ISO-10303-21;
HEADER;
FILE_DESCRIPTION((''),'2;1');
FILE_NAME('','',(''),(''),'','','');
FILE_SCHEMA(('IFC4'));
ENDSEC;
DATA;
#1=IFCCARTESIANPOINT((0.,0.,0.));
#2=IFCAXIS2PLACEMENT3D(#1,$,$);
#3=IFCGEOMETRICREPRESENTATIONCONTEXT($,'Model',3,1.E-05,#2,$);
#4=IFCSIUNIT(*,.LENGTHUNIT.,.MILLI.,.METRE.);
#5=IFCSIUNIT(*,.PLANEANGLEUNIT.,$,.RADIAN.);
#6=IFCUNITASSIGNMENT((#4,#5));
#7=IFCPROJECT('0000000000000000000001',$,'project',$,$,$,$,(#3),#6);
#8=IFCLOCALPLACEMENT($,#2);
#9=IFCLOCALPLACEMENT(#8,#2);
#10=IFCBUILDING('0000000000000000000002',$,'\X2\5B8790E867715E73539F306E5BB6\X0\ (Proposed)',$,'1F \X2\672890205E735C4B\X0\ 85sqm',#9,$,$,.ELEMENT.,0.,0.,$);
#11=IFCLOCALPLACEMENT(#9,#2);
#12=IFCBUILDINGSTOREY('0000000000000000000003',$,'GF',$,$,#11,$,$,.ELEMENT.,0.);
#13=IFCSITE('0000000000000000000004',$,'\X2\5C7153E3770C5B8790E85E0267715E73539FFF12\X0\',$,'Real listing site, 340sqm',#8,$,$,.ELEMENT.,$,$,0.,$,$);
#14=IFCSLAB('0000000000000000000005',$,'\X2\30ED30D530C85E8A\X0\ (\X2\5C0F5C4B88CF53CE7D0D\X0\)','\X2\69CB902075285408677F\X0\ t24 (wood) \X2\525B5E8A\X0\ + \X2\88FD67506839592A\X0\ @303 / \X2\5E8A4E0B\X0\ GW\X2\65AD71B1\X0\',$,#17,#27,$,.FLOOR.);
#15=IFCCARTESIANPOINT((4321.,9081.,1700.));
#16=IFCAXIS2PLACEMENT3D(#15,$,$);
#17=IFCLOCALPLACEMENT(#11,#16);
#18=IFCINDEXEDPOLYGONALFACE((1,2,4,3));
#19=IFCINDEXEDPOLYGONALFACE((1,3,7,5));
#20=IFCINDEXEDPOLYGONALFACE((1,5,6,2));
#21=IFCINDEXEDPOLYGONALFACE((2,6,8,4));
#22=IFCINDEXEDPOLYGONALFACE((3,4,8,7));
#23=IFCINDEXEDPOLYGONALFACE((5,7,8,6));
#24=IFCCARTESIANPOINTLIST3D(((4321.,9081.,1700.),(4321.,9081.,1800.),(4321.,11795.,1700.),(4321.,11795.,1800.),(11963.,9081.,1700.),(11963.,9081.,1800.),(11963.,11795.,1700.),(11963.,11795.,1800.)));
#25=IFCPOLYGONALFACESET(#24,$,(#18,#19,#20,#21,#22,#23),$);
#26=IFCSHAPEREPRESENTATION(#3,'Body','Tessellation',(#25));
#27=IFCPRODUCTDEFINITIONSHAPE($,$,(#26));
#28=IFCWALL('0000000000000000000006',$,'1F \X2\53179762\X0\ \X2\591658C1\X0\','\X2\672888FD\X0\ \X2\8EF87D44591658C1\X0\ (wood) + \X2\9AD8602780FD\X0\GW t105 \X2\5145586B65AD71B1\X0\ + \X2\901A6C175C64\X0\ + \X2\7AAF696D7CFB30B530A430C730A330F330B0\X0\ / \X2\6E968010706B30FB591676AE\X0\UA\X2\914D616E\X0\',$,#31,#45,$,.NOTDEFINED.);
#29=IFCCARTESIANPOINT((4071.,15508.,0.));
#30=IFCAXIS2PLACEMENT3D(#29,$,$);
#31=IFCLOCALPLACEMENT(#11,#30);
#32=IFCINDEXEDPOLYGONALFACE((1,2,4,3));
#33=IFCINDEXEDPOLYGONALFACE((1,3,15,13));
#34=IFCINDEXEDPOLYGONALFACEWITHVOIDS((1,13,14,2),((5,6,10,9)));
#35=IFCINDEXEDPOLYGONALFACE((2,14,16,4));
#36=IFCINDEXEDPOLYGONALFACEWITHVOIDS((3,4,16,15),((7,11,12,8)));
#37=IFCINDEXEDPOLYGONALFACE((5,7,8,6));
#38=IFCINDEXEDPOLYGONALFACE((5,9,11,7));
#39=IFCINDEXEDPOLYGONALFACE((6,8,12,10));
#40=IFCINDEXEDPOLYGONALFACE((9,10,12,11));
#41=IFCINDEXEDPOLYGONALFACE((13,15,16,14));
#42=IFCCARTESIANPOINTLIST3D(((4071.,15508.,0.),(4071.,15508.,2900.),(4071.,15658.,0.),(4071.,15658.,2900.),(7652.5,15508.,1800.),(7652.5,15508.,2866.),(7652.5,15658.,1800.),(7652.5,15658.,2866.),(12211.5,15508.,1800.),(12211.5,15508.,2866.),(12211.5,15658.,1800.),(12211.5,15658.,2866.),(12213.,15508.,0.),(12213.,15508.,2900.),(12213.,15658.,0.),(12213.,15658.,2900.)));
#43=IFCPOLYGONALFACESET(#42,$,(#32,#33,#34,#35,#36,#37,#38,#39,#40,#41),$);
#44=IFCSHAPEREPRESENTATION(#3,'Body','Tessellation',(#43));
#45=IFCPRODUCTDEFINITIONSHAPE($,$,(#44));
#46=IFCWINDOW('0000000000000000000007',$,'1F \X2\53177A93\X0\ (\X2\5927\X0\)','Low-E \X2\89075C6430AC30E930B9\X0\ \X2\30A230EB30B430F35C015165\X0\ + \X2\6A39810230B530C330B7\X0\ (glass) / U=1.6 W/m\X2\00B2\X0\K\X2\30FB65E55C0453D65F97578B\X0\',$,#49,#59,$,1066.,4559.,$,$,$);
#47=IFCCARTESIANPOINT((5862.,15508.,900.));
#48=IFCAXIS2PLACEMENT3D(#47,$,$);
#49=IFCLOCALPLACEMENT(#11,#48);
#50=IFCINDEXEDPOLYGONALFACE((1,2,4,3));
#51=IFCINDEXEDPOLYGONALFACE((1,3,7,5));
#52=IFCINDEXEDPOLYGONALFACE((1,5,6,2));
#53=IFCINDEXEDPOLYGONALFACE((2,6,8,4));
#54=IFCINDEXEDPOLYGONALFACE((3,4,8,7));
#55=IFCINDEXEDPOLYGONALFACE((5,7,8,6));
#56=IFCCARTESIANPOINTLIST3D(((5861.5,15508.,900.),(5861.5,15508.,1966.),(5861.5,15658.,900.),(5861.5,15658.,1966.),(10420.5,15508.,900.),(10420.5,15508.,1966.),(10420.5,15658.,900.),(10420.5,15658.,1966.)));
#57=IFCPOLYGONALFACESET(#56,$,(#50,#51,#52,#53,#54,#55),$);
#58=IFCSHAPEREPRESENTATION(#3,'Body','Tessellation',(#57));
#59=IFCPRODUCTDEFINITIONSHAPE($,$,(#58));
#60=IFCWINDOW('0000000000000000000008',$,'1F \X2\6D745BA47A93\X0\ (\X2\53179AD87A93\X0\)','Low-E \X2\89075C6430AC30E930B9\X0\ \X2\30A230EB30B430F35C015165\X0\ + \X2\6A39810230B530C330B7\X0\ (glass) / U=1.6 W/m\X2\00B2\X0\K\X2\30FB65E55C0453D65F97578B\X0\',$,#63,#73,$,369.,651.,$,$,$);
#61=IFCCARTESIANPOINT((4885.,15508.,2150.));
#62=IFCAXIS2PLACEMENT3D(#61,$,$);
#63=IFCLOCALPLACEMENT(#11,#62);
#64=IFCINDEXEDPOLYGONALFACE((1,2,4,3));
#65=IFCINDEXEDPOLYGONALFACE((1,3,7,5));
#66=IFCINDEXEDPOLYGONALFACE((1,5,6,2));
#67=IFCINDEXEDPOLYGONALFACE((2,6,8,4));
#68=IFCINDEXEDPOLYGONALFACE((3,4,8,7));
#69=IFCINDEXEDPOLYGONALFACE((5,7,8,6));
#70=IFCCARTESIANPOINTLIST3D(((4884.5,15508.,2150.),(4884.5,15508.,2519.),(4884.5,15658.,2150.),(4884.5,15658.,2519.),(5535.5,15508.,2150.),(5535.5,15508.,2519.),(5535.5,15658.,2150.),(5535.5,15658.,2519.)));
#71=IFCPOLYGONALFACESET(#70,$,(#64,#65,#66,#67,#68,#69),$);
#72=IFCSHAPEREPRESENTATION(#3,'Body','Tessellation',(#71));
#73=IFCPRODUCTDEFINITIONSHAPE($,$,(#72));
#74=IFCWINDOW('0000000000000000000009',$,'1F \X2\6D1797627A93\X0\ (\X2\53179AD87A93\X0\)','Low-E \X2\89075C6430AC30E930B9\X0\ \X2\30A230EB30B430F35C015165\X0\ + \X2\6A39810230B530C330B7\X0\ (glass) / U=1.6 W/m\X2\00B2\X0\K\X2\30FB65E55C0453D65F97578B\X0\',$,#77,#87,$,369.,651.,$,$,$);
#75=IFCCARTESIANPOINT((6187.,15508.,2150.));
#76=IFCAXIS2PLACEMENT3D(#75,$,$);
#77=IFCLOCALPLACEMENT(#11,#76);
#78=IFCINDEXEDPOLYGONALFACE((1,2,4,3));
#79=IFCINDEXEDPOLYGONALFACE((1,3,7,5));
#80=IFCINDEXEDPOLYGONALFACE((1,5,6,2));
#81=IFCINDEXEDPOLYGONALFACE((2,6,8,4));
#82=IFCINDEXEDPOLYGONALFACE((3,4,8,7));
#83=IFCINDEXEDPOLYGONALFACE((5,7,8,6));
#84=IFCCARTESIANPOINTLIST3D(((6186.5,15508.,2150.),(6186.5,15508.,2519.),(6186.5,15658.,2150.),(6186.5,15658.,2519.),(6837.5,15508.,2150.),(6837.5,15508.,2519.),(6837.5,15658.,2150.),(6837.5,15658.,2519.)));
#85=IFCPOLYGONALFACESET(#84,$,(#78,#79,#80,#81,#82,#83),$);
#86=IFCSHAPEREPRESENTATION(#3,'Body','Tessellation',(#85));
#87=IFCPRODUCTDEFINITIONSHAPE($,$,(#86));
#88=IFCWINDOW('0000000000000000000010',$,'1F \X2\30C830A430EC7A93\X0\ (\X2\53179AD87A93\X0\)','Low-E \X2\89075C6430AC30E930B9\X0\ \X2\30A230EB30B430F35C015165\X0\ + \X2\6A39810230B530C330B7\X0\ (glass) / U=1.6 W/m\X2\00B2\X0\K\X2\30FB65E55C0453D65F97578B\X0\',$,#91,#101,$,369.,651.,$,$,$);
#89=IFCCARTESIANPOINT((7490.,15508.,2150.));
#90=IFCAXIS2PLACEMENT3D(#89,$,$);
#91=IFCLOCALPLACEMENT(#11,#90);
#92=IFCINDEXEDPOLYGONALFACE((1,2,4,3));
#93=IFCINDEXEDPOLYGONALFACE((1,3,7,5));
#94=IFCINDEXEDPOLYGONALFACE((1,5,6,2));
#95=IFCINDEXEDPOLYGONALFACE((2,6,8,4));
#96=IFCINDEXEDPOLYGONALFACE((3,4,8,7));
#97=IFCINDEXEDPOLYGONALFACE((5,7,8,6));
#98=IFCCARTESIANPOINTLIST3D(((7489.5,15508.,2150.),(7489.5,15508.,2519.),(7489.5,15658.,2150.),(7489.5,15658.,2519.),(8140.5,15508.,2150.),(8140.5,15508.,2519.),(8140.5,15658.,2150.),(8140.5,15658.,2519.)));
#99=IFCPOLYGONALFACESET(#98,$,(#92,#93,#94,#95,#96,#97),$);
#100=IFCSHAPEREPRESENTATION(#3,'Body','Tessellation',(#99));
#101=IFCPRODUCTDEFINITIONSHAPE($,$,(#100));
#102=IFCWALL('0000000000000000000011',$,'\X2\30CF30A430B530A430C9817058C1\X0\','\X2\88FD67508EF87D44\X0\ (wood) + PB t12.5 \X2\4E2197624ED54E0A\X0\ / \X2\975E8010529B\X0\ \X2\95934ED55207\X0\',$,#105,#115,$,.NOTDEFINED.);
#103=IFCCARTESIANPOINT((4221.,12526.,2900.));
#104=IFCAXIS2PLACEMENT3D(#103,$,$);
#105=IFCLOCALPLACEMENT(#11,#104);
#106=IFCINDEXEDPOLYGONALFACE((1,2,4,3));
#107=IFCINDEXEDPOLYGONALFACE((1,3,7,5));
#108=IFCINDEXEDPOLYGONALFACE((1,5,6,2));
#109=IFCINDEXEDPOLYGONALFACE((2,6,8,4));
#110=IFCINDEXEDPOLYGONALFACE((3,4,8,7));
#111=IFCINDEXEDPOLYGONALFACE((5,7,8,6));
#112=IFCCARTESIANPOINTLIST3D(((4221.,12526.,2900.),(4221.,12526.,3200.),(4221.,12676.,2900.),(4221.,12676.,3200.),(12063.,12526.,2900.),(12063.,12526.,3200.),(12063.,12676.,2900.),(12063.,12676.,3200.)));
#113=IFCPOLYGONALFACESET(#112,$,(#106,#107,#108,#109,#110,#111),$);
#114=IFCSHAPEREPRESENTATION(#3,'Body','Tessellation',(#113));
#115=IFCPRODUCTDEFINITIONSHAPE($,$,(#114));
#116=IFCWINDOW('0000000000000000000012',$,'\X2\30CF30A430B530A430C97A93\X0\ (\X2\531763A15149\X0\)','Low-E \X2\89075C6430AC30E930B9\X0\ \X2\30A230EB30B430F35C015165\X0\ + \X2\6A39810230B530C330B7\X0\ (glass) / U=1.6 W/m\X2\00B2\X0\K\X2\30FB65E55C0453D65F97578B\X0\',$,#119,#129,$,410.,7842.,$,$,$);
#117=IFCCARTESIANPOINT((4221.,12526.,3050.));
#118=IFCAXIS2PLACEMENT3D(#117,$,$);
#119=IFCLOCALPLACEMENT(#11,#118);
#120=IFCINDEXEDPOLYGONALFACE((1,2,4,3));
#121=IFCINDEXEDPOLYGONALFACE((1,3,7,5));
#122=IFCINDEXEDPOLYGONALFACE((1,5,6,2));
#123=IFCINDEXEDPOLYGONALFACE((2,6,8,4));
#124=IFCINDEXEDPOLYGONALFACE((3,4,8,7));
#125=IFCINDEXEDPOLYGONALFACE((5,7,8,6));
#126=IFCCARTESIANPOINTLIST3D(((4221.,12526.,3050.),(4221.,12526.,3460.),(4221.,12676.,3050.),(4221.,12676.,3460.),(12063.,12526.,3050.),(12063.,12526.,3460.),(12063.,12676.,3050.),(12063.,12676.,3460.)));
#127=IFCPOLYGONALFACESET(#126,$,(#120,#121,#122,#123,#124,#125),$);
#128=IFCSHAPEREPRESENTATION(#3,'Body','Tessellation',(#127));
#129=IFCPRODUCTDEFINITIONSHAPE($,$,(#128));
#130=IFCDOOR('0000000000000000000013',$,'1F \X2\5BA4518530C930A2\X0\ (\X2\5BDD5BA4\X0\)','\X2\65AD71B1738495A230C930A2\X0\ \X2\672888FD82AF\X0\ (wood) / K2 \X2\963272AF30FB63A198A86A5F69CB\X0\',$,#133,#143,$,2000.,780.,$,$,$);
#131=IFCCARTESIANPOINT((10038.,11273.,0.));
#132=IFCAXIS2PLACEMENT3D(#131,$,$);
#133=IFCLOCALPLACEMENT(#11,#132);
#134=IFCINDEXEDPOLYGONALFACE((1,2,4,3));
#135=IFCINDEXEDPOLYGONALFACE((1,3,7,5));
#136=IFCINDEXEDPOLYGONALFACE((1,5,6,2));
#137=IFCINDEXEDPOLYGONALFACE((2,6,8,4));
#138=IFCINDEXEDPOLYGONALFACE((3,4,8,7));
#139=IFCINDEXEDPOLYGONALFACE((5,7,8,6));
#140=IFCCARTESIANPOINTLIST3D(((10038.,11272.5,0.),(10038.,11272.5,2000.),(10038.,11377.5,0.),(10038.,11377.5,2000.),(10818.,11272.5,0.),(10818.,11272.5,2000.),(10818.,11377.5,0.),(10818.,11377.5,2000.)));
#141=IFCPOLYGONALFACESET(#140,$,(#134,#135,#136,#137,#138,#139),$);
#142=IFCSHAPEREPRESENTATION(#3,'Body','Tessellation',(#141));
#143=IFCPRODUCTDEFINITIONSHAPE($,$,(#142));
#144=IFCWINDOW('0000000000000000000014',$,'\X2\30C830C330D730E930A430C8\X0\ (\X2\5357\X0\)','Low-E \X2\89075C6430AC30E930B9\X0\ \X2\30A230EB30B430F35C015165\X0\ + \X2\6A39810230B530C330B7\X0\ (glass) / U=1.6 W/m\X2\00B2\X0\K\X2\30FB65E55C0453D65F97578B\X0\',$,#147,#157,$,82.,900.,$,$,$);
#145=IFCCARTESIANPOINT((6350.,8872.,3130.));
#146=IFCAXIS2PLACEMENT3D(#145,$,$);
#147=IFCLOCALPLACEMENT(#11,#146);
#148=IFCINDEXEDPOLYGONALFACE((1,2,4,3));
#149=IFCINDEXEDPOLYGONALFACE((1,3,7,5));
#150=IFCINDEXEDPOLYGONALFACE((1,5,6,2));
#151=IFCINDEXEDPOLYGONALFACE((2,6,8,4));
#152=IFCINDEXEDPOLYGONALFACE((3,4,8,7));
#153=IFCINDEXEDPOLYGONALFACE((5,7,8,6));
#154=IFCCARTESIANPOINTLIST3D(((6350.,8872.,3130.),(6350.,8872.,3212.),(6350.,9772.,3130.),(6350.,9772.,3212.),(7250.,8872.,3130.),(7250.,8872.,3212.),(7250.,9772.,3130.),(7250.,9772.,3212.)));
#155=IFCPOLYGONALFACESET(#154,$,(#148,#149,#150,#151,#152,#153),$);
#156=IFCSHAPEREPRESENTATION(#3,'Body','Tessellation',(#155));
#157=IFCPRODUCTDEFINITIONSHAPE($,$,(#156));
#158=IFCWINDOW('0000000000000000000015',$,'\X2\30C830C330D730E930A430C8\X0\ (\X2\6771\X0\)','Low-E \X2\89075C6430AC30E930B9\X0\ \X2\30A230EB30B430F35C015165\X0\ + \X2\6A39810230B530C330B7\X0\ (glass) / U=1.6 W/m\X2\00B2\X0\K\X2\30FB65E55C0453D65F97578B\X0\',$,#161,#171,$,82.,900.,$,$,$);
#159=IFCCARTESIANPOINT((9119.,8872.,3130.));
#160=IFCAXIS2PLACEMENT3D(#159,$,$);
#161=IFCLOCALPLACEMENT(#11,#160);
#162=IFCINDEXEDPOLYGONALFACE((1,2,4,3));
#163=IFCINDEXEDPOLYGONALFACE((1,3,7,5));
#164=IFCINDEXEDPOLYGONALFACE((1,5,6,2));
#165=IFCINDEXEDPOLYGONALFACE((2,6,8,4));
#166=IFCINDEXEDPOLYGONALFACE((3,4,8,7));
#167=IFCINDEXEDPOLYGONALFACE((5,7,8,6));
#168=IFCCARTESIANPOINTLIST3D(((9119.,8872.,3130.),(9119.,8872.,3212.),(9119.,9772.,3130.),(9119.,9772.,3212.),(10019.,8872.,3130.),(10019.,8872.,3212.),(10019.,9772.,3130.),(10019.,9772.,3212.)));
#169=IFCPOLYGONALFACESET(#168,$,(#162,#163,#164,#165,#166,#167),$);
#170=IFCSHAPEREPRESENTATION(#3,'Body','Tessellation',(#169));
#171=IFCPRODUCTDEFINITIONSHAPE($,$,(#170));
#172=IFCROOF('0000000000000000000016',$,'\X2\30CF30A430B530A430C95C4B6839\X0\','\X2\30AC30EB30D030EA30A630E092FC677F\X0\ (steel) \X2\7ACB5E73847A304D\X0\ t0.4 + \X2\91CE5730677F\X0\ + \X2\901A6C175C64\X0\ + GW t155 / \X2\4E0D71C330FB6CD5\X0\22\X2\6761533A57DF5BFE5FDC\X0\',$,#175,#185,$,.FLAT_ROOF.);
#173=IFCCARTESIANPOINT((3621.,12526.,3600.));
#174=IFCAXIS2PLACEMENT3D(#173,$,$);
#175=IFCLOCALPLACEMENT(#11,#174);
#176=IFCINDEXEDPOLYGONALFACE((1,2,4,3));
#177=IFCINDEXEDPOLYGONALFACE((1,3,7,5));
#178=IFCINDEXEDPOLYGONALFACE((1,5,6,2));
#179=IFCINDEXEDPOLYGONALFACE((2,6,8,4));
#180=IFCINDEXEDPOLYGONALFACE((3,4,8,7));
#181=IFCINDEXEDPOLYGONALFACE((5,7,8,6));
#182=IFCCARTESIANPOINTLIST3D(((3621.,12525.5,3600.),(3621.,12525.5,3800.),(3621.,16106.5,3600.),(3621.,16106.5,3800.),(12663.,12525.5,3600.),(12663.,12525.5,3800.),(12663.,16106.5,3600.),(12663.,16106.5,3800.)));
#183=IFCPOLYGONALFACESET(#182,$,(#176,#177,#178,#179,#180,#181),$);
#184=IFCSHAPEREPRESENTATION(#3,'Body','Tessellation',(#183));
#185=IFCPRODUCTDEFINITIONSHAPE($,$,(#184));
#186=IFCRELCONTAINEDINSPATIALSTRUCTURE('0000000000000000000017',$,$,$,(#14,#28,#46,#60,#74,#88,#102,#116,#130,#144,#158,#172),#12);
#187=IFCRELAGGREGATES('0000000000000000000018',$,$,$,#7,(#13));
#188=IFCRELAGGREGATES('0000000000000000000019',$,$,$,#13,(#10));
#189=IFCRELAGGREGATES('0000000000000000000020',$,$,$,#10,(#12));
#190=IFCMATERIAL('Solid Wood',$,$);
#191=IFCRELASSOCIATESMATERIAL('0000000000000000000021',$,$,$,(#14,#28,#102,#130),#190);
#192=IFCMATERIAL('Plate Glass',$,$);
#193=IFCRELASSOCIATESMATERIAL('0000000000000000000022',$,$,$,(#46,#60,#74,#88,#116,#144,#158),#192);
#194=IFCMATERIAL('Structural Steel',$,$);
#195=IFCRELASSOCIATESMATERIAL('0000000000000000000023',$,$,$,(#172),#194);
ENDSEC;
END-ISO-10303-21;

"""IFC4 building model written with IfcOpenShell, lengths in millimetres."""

from ifc_helpers import new_model, si_unit, frame, frame_2d, origin, place, context, project, spatial, rectangle, extrude, material, element, fill, save


model = new_model("IFC4")

# Units and contexts
model_context = context("Model", 3, precision=1e-05, world=origin())
ifc_project = project(units=[si_unit("LENGTHUNIT", "METRE", prefix="MILLI"), si_unit("PLANEANGLEUNIT", "RADIAN")], contexts=[model_context])

# Site, building, storey
site_placement = place(None, origin())
site = spatial("IfcSite", under=ifc_project, at=site_placement, Name="山口県宇部市東平原２", ObjectType="Real listing site, 340sqm", CompositionType="ELEMENT", RefElevation=0.0)
building_placement = place(site_placement, origin())
building = spatial("IfcBuilding", under=site, at=building_placement, Name="宇部東平原の家 (Proposed)", ObjectType="1F 木造平屋 85sqm", CompositionType="ELEMENT", ElevationOfRefHeight=0.0, ElevationOfTerrain=0.0)
storey_placement = place(building_placement, origin())
storey = spatial("IfcBuildingStorey", under=building, at=storey_placement, Name="GF", CompositionType="ELEMENT", Elevation=0.0)

# Slab
ifc_material_1 = material(Name="Solid Wood")
slab_placement = place(storey_placement, frame((4321.0, 9081.0, 1700.0)))
element("IfcSlab", 1, at=slab_placement, inside=storey, material=ifc_material_1, Name="ロフト床 (小屋裏収納)", Description="構造用合板 t24 (wood) 剛床 + 製材根太 @303 / 床下 GW断熱", PredefinedType="FLOOR", context=model_context, shape_type="SweptSolid", body=[
    extrude(rectangle(XDim=7642.0, YDim=2714.0, at=frame_2d((3821.0, 1357.0))), frame((4321.0, 9081.0, 1700.0)), (0.0, 0.0, 1.0), 100.0),
])

# Wall, openings, windows
wall_1_placement = place(storey_placement, frame((4071.0, 15508.0, 0.0)))
wall_1 = element("IfcWall", 2, at=wall_1_placement, inside=storey, material=ifc_material_1, Name="1F 北面 外壁", Description="木製 軸組外壁 (wood) + 高性能GW t105 充填断熱 + 通気層 + 窯業系サイディング / 準耐火・外皮UA配慮", PredefinedType="NOTDEFINED", context=model_context, shape_type="SweptSolid", body=[
    extrude(rectangle(XDim=8142.0, YDim=150.0, at=frame_2d((4071.0, 75.0))), frame((4071.0, 15508.0, 0.0)), (0.0, 0.0, 1.0), 2900.0),
])
opening_1_placement = place(storey_placement, frame((5862.0, 15508.0, 900.0)))
opening_1 = element("IfcOpeningElement", 3, at=opening_1_placement, cuts=wall_1, PredefinedType="NOTDEFINED", context=model_context, shape_type="SweptSolid", body=[
    extrude(rectangle(XDim=4559.0, YDim=150.0, at=frame_2d((2279.0, 75.0))), frame((5862.0, 15508.0, 900.0)), (0.0, 0.0, 1.0), 1066.0),
])
opening_2_placement = place(storey_placement, frame((4885.0, 15508.0, 2150.0)))
opening_2 = element("IfcOpeningElement", 4, at=opening_2_placement, cuts=wall_1, PredefinedType="NOTDEFINED", context=model_context, shape_type="SweptSolid", body=[
    extrude(rectangle(XDim=651.0, YDim=150.0, at=frame_2d((325.0, 75.0))), frame((4885.0, 15508.0, 2150.0)), (0.0, 0.0, 1.0), 369.0),
])
opening_3_placement = place(storey_placement, frame((6187.0, 15508.0, 2150.0)))
opening_3 = element("IfcOpeningElement", 5, at=opening_3_placement, cuts=wall_1, PredefinedType="NOTDEFINED", context=model_context, shape_type="SweptSolid", body=[
    extrude(rectangle(XDim=651.0, YDim=150.0, at=frame_2d((325.0, 75.0))), frame((6187.0, 15508.0, 2150.0)), (0.0, 0.0, 1.0), 369.0),
])
opening_4_placement = place(storey_placement, frame((7490.0, 15508.0, 2150.0)))
opening_4 = element("IfcOpeningElement", 6, at=opening_4_placement, cuts=wall_1, PredefinedType="NOTDEFINED", context=model_context, shape_type="SweptSolid", body=[
    extrude(rectangle(XDim=651.0, YDim=150.0, at=frame_2d((325.0, 75.0))), frame((7490.0, 15508.0, 2150.0)), (0.0, 0.0, 1.0), 369.0),
])
ifc_material_2 = material(Name="Plate Glass")
window_1_placement = place(storey_placement, frame((5862.0, 15508.0, 900.0)))
window_1 = element("IfcWindow", 7, at=window_1_placement, inside=storey, material=ifc_material_2, Name="1F 北窓 (大)", Description="Low-E 複層ガラス アルゴン封入 + 樹脂サッシ (glass) / U=1.6 W/m²K・日射取得型", OverallHeight=1066.0, OverallWidth=4559.0, context=model_context, shape_type="SweptSolid", body=[
    extrude(rectangle(XDim=4559.0, YDim=150.0, at=frame_2d((2279.0, 75.0))), frame((5862.0, 15508.0, 900.0)), (0.0, 0.0, 1.0), 1066.0),
])
fill(opening_1, window_1)
window_2_placement = place(storey_placement, frame((4885.0, 15508.0, 2150.0)))
window_2 = element("IfcWindow", 8, at=window_2_placement, inside=storey, material=ifc_material_2, Name="1F 浴室窓 (北高窓)", Description="Low-E 複層ガラス アルゴン封入 + 樹脂サッシ (glass) / U=1.6 W/m²K・日射取得型", OverallHeight=369.0, OverallWidth=651.0, context=model_context, shape_type="SweptSolid", body=[
    extrude(rectangle(XDim=651.0, YDim=150.0, at=frame_2d((325.0, 75.0))), frame((4885.0, 15508.0, 2150.0)), (0.0, 0.0, 1.0), 369.0),
])
fill(opening_2, window_2)
window_3_placement = place(storey_placement, frame((6187.0, 15508.0, 2150.0)))
window_3 = element("IfcWindow", 9, at=window_3_placement, inside=storey, material=ifc_material_2, Name="1F 洗面窓 (北高窓)", Description="Low-E 複層ガラス アルゴン封入 + 樹脂サッシ (glass) / U=1.6 W/m²K・日射取得型", OverallHeight=369.0, OverallWidth=651.0, context=model_context, shape_type="SweptSolid", body=[
    extrude(rectangle(XDim=651.0, YDim=150.0, at=frame_2d((325.0, 75.0))), frame((6187.0, 15508.0, 2150.0)), (0.0, 0.0, 1.0), 369.0),
])
fill(opening_3, window_3)
window_4_placement = place(storey_placement, frame((7490.0, 15508.0, 2150.0)))
window_4 = element("IfcWindow", 10, at=window_4_placement, inside=storey, material=ifc_material_2, Name="1F トイレ窓 (北高窓)", Description="Low-E 複層ガラス アルゴン封入 + 樹脂サッシ (glass) / U=1.6 W/m²K・日射取得型", OverallHeight=369.0, OverallWidth=651.0, context=model_context, shape_type="SweptSolid", body=[
    extrude(rectangle(XDim=651.0, YDim=150.0, at=frame_2d((325.0, 75.0))), frame((7490.0, 15508.0, 2150.0)), (0.0, 0.0, 1.0), 369.0),
])
fill(opening_4, window_4)

# Wall, opening, window
wall_2_placement = place(storey_placement, frame((4221.0, 12526.0, 2900.0)))
wall_2 = element("IfcWall", 11, at=wall_2_placement, inside=storey, material=ifc_material_1, Name="ハイサイド腰壁", Description="製材軸組 (wood) + PB t12.5 両面仕上 / 非耐力 間仕切", PredefinedType="NOTDEFINED", context=model_context, shape_type="SweptSolid", body=[
    extrude(rectangle(XDim=7842.0, YDim=150.0, at=frame_2d((3921.0, 75.0))), frame((4221.0, 12526.0, 2900.0)), (0.0, 0.0, 1.0), 700.0),
])
opening_5_placement = place(storey_placement, frame((4221.0, 12526.0, 3050.0)))
opening_5 = element("IfcOpeningElement", 12, at=opening_5_placement, cuts=wall_2, PredefinedType="NOTDEFINED", context=model_context, shape_type="SweptSolid", body=[
    extrude(rectangle(XDim=7842.0, YDim=150.0, at=frame_2d((3921.0, 75.0))), frame((4221.0, 12526.0, 3050.0)), (0.0, 0.0, 1.0), 410.0),
])
window_5_placement = place(storey_placement, frame((4221.0, 12526.0, 3050.0)))
window_5 = element("IfcWindow", 13, at=window_5_placement, inside=storey, material=ifc_material_2, Name="ハイサイド窓 (北採光)", Description="Low-E 複層ガラス アルゴン封入 + 樹脂サッシ (glass) / U=1.6 W/m²K・日射取得型", OverallHeight=410.0, OverallWidth=7842.0, context=model_context, shape_type="SweptSolid", body=[
    extrude(rectangle(XDim=7842.0, YDim=150.0, at=frame_2d((3921.0, 75.0))), frame((4221.0, 12526.0, 3050.0)), (0.0, 0.0, 1.0), 410.0),
])
fill(opening_5, window_5)

# Door
door_1_placement = place(storey_placement, frame((10038.0, 11273.0, 0.0)))
element("IfcDoor", 14, at=door_1_placement, inside=storey, material=ifc_material_1, Name="1F 室内ドア (寝室)", Description="断熱玄関ドア 木製芯 (wood) / K2 防犯・採風機構", OverallHeight=2000.0, OverallWidth=780.0, context=model_context, shape_type="SweptSolid", body=[
    extrude(rectangle(XDim=780.0, YDim=105.0, at=frame_2d((390.0, 52.0))), frame((10038.0, 11273.0, 0.0)), (0.0, 0.0, 1.0), 2000.0),
])

# Windows
window_6_placement = place(storey_placement, frame((6350.0, 8872.0, 3130.0)))
element("IfcWindow", 15, at=window_6_placement, inside=storey, material=ifc_material_2, Name="トップライト (南)", Description="Low-E 複層ガラス アルゴン封入 + 樹脂サッシ (glass) / U=1.6 W/m²K・日射取得型", OverallHeight=82.0, OverallWidth=900.0, context=model_context, shape_type="SweptSolid", body=[
    extrude(rectangle(XDim=900.0, YDim=900.0, at=frame_2d((450.0, 450.0))), frame((6350.0, 8872.0, 3130.0)), (0.0, 0.0, 1.0), 82.0),
])
window_7_placement = place(storey_placement, frame((9119.0, 8872.0, 3130.0)))
element("IfcWindow", 16, at=window_7_placement, inside=storey, material=ifc_material_2, Name="トップライト (東)", Description="Low-E 複層ガラス アルゴン封入 + 樹脂サッシ (glass) / U=1.6 W/m²K・日射取得型", OverallHeight=82.0, OverallWidth=900.0, context=model_context, shape_type="SweptSolid", body=[
    extrude(rectangle(XDim=900.0, YDim=900.0, at=frame_2d((450.0, 450.0))), frame((9119.0, 8872.0, 3130.0)), (0.0, 0.0, 1.0), 82.0),
])

# Roof
ifc_material_3 = material(Name="Structural Steel")
roof_placement = place(storey_placement, frame((3621.0, 12526.0, 3600.0)))
element("IfcRoof", 17, at=roof_placement, inside=storey, material=ifc_material_3, Name="ハイサイド屋根", Description="ガルバリウム鋼板 (steel) 立平葺き t0.4 + 野地板 + 通気層 + GW t155 / 不燃・法22条区域対応", PredefinedType="FLAT_ROOF", context=model_context, shape_type="SweptSolid", body=[
    extrude(rectangle(XDim=9042.0, YDim=3581.0, at=frame_2d((4521.0, 1790.0))), frame((3621.0, 12526.0, 3600.0)), (0.0, 0.0, 1.0), 200.0),
])

save(model, "model.ifc")
